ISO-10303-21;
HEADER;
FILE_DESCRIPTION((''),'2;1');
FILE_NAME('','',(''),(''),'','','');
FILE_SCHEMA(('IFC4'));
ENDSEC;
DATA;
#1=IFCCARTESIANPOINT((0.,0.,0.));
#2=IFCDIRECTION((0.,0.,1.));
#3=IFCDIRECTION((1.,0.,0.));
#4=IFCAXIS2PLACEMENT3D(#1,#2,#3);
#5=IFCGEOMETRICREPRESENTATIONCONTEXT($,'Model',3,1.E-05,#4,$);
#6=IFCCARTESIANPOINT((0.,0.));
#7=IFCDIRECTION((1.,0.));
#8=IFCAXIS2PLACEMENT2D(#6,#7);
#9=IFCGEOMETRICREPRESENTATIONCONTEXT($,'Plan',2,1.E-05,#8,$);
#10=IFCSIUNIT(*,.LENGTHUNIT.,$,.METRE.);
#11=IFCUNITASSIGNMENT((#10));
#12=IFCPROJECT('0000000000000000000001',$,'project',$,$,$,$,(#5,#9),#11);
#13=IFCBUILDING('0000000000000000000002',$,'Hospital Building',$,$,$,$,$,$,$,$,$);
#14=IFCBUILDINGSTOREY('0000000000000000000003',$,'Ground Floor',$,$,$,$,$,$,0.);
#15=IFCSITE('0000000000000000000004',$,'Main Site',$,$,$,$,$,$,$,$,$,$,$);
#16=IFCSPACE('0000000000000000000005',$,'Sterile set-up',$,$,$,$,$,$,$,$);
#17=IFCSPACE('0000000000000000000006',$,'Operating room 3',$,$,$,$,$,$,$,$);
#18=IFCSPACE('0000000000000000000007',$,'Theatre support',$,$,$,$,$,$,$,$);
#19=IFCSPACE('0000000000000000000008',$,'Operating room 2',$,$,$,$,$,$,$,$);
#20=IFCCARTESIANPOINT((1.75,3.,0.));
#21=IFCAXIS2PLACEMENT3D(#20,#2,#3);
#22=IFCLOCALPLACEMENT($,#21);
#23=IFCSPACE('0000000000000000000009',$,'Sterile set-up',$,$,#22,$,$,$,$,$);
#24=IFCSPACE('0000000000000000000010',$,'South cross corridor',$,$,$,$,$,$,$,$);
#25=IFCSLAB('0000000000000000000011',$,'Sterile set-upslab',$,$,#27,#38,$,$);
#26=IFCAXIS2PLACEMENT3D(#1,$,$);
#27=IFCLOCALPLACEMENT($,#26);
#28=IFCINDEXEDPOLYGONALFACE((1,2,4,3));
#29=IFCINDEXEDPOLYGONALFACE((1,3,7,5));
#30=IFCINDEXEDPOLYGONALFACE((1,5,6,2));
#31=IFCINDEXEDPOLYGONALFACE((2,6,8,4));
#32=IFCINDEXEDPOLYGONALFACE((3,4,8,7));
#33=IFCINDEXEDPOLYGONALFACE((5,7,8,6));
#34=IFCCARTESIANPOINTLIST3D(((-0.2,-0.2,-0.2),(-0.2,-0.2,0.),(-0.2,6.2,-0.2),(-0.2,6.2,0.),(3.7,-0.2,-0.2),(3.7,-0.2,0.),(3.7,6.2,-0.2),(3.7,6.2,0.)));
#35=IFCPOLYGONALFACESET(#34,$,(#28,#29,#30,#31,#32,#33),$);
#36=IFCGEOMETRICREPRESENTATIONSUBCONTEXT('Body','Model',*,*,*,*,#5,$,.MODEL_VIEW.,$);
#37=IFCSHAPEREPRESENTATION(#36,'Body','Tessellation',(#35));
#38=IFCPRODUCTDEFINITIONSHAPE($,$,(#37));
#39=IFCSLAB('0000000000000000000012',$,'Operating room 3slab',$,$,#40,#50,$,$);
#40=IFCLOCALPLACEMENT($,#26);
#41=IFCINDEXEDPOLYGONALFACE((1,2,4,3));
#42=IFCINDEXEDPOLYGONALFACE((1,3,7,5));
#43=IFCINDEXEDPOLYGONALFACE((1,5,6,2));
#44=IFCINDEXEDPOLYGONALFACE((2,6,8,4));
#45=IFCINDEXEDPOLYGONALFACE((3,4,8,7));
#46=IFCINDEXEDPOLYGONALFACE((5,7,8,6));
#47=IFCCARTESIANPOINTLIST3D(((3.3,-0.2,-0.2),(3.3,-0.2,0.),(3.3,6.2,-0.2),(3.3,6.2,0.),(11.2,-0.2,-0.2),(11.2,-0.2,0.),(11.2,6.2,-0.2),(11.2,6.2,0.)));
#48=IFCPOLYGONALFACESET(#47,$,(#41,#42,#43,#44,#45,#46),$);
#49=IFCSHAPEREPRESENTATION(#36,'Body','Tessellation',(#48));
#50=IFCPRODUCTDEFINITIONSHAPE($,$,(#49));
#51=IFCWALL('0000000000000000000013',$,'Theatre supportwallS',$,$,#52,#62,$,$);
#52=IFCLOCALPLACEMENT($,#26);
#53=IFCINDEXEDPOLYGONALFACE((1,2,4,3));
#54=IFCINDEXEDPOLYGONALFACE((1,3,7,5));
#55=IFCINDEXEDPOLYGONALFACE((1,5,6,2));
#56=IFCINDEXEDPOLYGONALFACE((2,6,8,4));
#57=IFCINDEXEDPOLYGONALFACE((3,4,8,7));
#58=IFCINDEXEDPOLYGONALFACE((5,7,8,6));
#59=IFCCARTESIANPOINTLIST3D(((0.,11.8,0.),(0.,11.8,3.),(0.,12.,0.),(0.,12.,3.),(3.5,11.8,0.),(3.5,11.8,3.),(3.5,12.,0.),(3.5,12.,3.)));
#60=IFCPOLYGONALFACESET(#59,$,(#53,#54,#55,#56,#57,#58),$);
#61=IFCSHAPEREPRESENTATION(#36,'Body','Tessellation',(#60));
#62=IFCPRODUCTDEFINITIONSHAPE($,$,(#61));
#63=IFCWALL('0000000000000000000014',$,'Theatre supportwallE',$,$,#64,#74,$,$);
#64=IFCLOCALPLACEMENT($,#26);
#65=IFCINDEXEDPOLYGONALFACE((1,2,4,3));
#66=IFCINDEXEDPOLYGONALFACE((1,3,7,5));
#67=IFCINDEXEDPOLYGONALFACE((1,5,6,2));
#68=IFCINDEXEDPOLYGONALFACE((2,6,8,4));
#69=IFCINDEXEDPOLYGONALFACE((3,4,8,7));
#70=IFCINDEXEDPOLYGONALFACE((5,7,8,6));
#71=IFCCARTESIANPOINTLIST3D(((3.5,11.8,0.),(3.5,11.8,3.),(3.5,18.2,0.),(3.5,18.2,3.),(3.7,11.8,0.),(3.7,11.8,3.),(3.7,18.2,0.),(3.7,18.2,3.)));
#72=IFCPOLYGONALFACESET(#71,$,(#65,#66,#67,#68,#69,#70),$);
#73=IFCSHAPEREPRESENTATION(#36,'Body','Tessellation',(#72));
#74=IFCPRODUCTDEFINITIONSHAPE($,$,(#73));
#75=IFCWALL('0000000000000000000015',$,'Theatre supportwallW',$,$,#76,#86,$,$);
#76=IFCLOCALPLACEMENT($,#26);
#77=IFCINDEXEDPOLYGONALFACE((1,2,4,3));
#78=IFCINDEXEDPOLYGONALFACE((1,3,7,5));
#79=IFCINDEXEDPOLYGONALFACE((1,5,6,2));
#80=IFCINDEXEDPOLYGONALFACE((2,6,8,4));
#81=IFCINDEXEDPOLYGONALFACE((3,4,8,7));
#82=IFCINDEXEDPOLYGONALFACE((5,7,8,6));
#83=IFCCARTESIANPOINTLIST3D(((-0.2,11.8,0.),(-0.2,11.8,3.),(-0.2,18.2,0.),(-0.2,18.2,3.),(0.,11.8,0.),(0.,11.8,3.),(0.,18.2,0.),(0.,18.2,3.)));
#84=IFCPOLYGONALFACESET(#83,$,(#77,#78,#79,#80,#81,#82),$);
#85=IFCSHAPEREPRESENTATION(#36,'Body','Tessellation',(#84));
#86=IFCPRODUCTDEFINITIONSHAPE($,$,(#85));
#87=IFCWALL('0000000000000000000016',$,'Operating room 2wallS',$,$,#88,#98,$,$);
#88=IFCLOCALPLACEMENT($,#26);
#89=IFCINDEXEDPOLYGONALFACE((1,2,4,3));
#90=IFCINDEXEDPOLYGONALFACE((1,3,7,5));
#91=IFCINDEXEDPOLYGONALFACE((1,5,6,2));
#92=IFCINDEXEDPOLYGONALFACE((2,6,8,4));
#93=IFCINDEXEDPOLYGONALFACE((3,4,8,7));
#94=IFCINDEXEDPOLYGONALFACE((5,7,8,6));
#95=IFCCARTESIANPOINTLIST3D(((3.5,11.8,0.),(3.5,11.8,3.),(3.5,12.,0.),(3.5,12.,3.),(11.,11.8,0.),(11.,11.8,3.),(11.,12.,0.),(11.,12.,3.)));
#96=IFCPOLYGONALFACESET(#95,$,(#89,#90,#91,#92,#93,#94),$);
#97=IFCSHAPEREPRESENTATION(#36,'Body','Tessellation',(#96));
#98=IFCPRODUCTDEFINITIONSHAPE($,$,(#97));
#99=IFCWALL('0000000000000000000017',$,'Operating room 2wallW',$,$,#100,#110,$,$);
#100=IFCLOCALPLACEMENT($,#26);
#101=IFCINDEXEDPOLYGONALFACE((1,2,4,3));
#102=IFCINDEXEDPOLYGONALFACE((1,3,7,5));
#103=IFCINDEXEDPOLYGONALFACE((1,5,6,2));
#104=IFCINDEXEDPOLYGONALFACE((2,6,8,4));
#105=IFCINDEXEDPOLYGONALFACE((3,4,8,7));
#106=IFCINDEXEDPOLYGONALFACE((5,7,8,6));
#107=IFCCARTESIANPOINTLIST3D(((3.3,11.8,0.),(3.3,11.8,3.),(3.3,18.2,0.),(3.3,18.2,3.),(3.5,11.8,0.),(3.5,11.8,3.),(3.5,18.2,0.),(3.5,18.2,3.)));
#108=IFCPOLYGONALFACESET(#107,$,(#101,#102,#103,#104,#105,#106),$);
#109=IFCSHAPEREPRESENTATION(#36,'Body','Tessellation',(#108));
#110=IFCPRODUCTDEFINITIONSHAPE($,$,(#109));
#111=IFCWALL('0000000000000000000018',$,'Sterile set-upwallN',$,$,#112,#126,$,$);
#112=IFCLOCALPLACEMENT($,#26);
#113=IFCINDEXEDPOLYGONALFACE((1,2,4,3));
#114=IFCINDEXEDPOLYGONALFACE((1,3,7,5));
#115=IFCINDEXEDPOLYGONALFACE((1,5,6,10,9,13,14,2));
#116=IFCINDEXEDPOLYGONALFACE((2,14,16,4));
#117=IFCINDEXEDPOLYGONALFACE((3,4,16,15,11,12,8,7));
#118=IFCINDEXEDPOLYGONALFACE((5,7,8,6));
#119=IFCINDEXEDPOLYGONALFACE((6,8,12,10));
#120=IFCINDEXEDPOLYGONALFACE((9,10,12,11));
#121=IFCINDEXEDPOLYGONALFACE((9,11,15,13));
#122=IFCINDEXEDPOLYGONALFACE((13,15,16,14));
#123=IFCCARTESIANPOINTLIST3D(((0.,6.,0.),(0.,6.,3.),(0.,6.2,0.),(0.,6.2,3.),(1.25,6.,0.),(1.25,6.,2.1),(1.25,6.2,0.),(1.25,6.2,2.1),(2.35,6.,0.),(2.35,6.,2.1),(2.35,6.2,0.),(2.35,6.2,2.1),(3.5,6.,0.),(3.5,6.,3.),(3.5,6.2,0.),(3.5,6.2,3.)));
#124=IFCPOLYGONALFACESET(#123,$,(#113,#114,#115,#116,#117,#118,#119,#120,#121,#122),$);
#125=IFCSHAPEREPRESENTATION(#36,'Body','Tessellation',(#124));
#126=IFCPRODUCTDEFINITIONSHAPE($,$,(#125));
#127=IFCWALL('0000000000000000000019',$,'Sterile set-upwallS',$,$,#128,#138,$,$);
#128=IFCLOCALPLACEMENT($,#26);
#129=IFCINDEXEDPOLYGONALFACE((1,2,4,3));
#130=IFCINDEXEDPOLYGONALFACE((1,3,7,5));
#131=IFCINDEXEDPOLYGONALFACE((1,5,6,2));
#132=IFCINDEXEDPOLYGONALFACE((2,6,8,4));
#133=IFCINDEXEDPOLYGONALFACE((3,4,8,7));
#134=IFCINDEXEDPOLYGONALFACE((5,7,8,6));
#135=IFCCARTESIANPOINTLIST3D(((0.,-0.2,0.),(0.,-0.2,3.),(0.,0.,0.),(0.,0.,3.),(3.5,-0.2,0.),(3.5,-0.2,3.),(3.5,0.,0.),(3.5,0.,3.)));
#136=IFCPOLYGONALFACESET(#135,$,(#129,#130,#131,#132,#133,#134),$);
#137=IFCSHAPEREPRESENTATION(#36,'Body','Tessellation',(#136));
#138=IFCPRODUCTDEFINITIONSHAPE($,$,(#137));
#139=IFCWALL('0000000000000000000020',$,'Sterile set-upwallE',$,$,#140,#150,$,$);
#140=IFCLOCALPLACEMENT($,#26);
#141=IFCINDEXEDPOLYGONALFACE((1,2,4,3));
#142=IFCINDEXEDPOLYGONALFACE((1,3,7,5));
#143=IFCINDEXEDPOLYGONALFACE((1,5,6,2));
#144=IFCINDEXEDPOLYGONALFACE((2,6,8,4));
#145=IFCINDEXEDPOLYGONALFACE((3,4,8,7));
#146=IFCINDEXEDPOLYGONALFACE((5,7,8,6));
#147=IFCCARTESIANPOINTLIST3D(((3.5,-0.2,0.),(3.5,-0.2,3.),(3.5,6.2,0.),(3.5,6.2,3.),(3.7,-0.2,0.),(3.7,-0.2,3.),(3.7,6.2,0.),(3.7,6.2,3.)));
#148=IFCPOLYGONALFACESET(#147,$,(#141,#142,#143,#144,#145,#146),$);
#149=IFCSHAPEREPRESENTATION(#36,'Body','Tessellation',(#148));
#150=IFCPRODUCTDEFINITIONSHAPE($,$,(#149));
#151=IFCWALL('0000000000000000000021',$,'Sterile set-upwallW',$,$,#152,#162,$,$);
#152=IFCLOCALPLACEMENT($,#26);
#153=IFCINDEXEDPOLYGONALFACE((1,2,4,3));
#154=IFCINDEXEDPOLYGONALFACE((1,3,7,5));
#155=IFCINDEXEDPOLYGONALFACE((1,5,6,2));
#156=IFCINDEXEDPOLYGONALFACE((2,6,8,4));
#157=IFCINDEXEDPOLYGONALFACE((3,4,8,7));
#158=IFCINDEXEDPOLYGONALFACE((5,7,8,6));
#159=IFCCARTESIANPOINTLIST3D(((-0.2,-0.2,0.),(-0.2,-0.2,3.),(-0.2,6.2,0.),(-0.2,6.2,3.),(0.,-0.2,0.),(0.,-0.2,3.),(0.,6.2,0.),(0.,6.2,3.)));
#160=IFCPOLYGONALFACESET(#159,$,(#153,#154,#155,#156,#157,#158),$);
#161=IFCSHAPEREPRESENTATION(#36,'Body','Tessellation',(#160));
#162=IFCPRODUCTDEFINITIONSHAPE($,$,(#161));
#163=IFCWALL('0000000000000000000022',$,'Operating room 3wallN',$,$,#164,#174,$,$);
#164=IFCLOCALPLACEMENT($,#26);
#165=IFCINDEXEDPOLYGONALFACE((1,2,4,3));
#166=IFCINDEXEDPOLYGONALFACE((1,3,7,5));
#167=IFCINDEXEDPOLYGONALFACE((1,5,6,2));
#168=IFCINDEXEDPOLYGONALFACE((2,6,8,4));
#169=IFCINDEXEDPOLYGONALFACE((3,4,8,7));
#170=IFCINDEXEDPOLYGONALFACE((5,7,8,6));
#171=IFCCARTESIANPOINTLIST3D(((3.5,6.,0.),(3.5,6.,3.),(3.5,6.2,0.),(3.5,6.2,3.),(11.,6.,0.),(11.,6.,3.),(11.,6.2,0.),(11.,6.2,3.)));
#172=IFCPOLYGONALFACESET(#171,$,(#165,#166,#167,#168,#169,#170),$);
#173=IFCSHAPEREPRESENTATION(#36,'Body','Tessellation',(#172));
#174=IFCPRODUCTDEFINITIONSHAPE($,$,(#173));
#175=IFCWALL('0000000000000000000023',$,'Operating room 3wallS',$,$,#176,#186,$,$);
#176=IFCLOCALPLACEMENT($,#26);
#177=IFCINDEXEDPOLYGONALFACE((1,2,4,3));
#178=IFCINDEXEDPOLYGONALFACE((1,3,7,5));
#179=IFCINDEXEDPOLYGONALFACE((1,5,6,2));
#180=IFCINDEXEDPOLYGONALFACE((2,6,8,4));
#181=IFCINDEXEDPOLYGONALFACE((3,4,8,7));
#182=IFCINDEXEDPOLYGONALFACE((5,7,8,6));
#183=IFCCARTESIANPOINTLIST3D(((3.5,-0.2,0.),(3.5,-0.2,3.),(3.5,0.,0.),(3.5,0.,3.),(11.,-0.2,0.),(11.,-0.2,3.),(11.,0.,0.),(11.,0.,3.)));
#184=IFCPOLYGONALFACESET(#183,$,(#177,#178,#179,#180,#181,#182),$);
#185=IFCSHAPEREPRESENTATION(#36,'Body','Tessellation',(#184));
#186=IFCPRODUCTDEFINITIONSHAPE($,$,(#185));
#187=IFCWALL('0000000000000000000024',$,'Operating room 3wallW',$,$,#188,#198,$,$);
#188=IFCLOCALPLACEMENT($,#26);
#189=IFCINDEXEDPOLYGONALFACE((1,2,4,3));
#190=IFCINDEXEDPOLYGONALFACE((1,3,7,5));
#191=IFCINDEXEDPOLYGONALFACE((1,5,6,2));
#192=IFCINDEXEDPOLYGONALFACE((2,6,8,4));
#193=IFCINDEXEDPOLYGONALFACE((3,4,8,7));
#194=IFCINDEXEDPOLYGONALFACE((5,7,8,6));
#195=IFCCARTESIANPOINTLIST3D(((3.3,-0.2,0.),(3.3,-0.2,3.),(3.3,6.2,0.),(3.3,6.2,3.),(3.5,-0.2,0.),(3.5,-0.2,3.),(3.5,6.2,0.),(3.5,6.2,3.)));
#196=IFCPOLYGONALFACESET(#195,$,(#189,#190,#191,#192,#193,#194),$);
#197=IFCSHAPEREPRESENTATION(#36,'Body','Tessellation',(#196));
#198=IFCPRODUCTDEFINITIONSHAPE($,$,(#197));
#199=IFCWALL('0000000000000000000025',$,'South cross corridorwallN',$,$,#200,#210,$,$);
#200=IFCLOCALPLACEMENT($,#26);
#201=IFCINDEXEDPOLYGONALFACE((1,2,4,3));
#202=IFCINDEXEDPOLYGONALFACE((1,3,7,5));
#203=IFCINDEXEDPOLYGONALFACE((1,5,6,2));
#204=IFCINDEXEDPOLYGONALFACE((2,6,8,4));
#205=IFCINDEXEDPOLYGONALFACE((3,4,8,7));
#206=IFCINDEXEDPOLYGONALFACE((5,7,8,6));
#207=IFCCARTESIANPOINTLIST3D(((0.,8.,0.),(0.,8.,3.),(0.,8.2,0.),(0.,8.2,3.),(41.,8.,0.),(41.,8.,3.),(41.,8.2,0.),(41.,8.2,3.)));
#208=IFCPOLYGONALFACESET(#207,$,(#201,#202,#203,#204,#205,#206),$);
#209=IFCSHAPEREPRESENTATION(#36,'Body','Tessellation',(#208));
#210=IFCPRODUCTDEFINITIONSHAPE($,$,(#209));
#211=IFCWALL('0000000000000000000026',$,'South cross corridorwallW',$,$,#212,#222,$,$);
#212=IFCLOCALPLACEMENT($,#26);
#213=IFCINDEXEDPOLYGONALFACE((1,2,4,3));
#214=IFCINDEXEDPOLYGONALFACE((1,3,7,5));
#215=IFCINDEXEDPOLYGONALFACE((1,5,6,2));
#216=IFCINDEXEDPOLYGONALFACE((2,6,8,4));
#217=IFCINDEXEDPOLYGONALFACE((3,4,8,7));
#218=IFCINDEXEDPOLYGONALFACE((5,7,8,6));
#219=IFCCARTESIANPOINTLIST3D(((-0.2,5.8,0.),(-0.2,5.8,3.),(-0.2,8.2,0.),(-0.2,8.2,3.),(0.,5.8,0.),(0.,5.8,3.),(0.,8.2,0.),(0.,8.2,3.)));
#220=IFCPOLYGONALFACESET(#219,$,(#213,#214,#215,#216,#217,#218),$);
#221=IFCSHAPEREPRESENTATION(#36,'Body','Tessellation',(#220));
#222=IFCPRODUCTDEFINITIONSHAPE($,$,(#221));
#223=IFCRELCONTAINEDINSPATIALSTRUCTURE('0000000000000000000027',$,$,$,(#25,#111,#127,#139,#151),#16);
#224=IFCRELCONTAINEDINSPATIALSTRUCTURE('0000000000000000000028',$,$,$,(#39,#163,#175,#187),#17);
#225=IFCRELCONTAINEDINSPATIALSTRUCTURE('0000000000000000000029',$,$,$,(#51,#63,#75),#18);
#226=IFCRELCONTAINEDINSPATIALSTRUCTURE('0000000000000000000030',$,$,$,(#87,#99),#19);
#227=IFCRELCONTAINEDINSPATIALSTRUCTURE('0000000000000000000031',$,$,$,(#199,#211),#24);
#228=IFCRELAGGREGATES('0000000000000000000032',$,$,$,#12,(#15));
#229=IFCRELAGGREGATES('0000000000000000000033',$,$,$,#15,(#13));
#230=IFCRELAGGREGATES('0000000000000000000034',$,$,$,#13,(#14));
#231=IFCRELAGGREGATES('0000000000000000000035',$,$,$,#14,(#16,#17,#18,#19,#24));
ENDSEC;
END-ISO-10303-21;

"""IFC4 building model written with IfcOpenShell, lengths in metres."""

from ifc_helpers import new_model, si_unit, frame, origin_with_axes, origin_2d_with_axis, place, context, subcontext, project, spatial, indexed_curve, rectangle, outline, extrude, element, save


model = new_model("IFC4")

# Units and contexts
model_context = context("Model", 3, precision=1e-05, world=origin_with_axes())
plan_context = context("Plan", 2, precision=1e-05, world=origin_2d_with_axis())
body_context = subcontext(model_context, "Body", "Model", "MODEL_VIEW")
ifc_project = project(units=[si_unit("LENGTHUNIT", "METRE")], contexts=[model_context, plan_context])

# Site, building, storey, space
site = spatial("IfcSite", under=ifc_project, Name="Main Site")
building = spatial("IfcBuilding", under=site, Name="Hospital Building")
storey = spatial("IfcBuildingStorey", under=building, Name="Ground Floor", Elevation=0.0)
space_1 = spatial("IfcSpace", under=storey, Name="Sterile set-up")

# Slab
slab_1_placement = place(None, frame((1.75, 3.0, -0.2), z_axis=(0.0, 0.0, 1.0), x_axis=(1.0, 0.0, 0.0)))
element("IfcSlab", 1, at=slab_1_placement, inside=space_1, Name="Sterile set-upslab", context=body_context, shape_type="SweptSolid", body=[
    extrude(rectangle(XDim=3.9, YDim=6.4), origin_with_axes(), (0.0, 0.0, 1.0), 0.2),
])

# Shared definitions
space_2 = spatial("IfcSpace", under=storey, Name="Operating room 3")

# Slab
slab_2_placement = place(None, frame((7.25, 3.0, -0.2), z_axis=(0.0, 0.0, 1.0), x_axis=(1.0, 0.0, 0.0)))
element("IfcSlab", 2, at=slab_2_placement, inside=space_2, Name="Operating room 3slab", context=body_context, shape_type="SweptSolid", body=[
    extrude(rectangle(XDim=7.9, YDim=6.4), origin_with_axes(), (0.0, 0.0, 1.0), 0.2),
])

# Shared definitions
space_3 = spatial("IfcSpace", under=storey, Name="Theatre support")

# Walls
wall_1_placement = place(None, frame((0.0, 11.8, 0.0), z_axis=(0.0, 0.0, 1.0), x_axis=(1.0, 0.0, 0.0)))
element("IfcWall", 3, at=wall_1_placement, inside=space_3, Name="Theatre supportwallS", context=body_context, shape_type="SweptSolid", body=[
    extrude(outline(indexed_curve([(0.0, 0.0), (0.0, 0.2), (3.5, 0.2), (3.5, 0.0), (0.0, 0.0)], self_intersect=False)), origin_with_axes(), (0.0, 0.0, 1.0), 3.0),
])
for number, where, z_axis, x_axis, name in (
    (4, (3.7, 11.8, 0.0), (0.0, 0.0, 1.0), (0.0, 1.0, 0.0), "Theatre supportwallE"),
    (5, (0.0, 11.8, 0.0), (0.0, 0.0, 1.0), (0.0, 1.0, 0.0), "Theatre supportwallW"),
):
    element("IfcWall", number, at=place(None, frame(where, z_axis=z_axis, x_axis=x_axis)), inside=space_3, Name=name, context=body_context, shape_type="SweptSolid", body=[
        extrude(outline(indexed_curve([(0.0, 0.0), (0.0, 0.2), (6.4, 0.2), (6.4, 0.0), (0.0, 0.0)], self_intersect=False)), origin_with_axes(), (0.0, 0.0, 1.0), 3.0),
    ])

# Shared definitions
space_4 = spatial("IfcSpace", under=storey, Name="Operating room 2")

# Walls
wall_2_placement = place(None, frame((3.5, 11.8, 0.0), z_axis=(0.0, 0.0, 1.0), x_axis=(1.0, 0.0, 0.0)))
element("IfcWall", 6, at=wall_2_placement, inside=space_4, Name="Operating room 2wallS", context=body_context, shape_type="SweptSolid", body=[
    extrude(outline(indexed_curve([(0.0, 0.0), (0.0, 0.2), (7.5, 0.2), (7.5, 0.0), (0.0, 0.0)], self_intersect=False)), origin_with_axes(), (0.0, 0.0, 1.0), 3.0),
])
wall_3_placement = place(None, frame((3.5, 11.8, 0.0), z_axis=(0.0, 0.0, 1.0), x_axis=(0.0, 1.0, 0.0)))
element("IfcWall", 7, at=wall_3_placement, inside=space_4, Name="Operating room 2wallW", context=body_context, shape_type="SweptSolid", body=[
    extrude(outline(indexed_curve([(0.0, 0.0), (0.0, 0.2), (6.4, 0.2), (6.4, 0.0), (0.0, 0.0)], self_intersect=False)), origin_with_axes(), (0.0, 0.0, 1.0), 3.0),
])

# Wall
wall_4_placement = place(None, frame((0.0, 6.0, 0.0), z_axis=(0.0, 0.0, 1.0), x_axis=(1.0, 0.0, 0.0)))
wall_4 = element("IfcWall", 8, at=wall_4_placement, inside=space_1, Name="Sterile set-upwallN", context=body_context, shape_type="SweptSolid", body=[
    extrude(outline(indexed_curve([(0.0, 0.0), (0.0, 0.2), (3.5, 0.2), (3.5, 0.0), (0.0, 0.0)], self_intersect=False)), origin_with_axes(), (0.0, 0.0, 1.0), 3.0),
])

# Shared definitions
space_5_placement = place(None, frame((1.75, 3.0, 0.0), z_axis=(0.0, 0.0, 1.0), x_axis=(1.0, 0.0, 0.0)))
space_5 = spatial("IfcSpace", at=space_5_placement, Name="Sterile set-up")

# Opening
opening_1_placement = place(wall_4_placement, frame((1.25, -0.1, 0.0), z_axis=(0.0, 0.0, 1.0), x_axis=(1.0, 0.0, 0.0)))
element("IfcOpeningElement", 9, at=opening_1_placement, inside=space_5, cuts=wall_4, context=body_context, shape_type="SweptSolid", body=[
    extrude(outline(indexed_curve([(0.0, 0.0), (0.0, 0.4), (1.1, 0.4), (1.1, 0.0), (0.0, 0.0)], self_intersect=False)), origin_with_axes(), (0.0, 0.0, 1.0), 2.1),
])

# Walls
wall_5_placement = place(None, frame((0.0, -0.2, 0.0), z_axis=(0.0, 0.0, 1.0), x_axis=(1.0, 0.0, 0.0)))
element("IfcWall", 10, at=wall_5_placement, inside=space_1, Name="Sterile set-upwallS", context=body_context, shape_type="SweptSolid", body=[
    extrude(outline(indexed_curve([(0.0, 0.0), (0.0, 0.2), (3.5, 0.2), (3.5, 0.0), (0.0, 0.0)], self_intersect=False)), origin_with_axes(), (0.0, 0.0, 1.0), 3.0),
])
for number, where, z_axis, x_axis, name in (
    (11, (3.7, -0.2, 0.0), (0.0, 0.0, 1.0), (0.0, 1.0, 0.0), "Sterile set-upwallE"),
    (12, (0.0, -0.2, 0.0), (0.0, 0.0, 1.0), (0.0, 1.0, 0.0), "Sterile set-upwallW"),
):
    element("IfcWall", number, at=place(None, frame(where, z_axis=z_axis, x_axis=x_axis)), inside=space_1, Name=name, context=body_context, shape_type="SweptSolid", body=[
        extrude(outline(indexed_curve([(0.0, 0.0), (0.0, 0.2), (6.4, 0.2), (6.4, 0.0), (0.0, 0.0)], self_intersect=False)), origin_with_axes(), (0.0, 0.0, 1.0), 3.0),
    ])
for number, where, z_axis, x_axis, name in (
    (13, (3.5, 6.0, 0.0), (0.0, 0.0, 1.0), (1.0, 0.0, 0.0), "Operating room 3wallN"),
    (14, (3.5, -0.2, 0.0), (0.0, 0.0, 1.0), (1.0, 0.0, 0.0), "Operating room 3wallS"),
):
    element("IfcWall", number, at=place(None, frame(where, z_axis=z_axis, x_axis=x_axis)), inside=space_2, Name=name, context=body_context, shape_type="SweptSolid", body=[
        extrude(outline(indexed_curve([(0.0, 0.0), (0.0, 0.2), (7.5, 0.2), (7.5, 0.0), (0.0, 0.0)], self_intersect=False)), origin_with_axes(), (0.0, 0.0, 1.0), 3.0),
    ])
wall_6_placement = place(None, frame((3.5, -0.2, 0.0), z_axis=(0.0, 0.0, 1.0), x_axis=(0.0, 1.0, 0.0)))
element("IfcWall", 15, at=wall_6_placement, inside=space_2, Name="Operating room 3wallW", context=body_context, shape_type="SweptSolid", body=[
    extrude(outline(indexed_curve([(0.0, 0.0), (0.0, 0.2), (6.4, 0.2), (6.4, 0.0), (0.0, 0.0)], self_intersect=False)), origin_with_axes(), (0.0, 0.0, 1.0), 3.0),
])

# Shared definitions
space_6 = spatial("IfcSpace", under=storey, Name="South cross corridor")

# Wall
wall_7_placement = place(None, frame((0.0, 8.0, 0.0), z_axis=(0.0, 0.0, 1.0), x_axis=(1.0, 0.0, 0.0)))
element("IfcWall", 16, at=wall_7_placement, inside=space_6, Name="South cross corridorwallN", context=body_context, shape_type="SweptSolid", body=[
    extrude(outline(indexed_curve([(0.0, 0.0), (0.0, 0.2), (41.0, 0.2), (41.0, 0.0), (0.0, 0.0)], self_intersect=False)), origin_with_axes(), (0.0, 0.0, 1.0), 3.0),
])

# Wall
wall_8_placement = place(None, frame((0.0, 5.8, 0.0), z_axis=(0.0, 0.0, 1.0), x_axis=(0.0, 1.0, 0.0)))
element("IfcWall", 17, at=wall_8_placement, inside=space_6, Name="South cross corridorwallW", context=body_context, shape_type="SweptSolid", body=[
    extrude(outline(indexed_curve([(0.0, 0.0), (0.0, 0.2), (2.4, 0.2), (2.4, 0.0), (0.0, 0.0)], self_intersect=False)), origin_with_axes(), (0.0, 0.0, 1.0), 3.0),
])

save(model, "model.ifc")
